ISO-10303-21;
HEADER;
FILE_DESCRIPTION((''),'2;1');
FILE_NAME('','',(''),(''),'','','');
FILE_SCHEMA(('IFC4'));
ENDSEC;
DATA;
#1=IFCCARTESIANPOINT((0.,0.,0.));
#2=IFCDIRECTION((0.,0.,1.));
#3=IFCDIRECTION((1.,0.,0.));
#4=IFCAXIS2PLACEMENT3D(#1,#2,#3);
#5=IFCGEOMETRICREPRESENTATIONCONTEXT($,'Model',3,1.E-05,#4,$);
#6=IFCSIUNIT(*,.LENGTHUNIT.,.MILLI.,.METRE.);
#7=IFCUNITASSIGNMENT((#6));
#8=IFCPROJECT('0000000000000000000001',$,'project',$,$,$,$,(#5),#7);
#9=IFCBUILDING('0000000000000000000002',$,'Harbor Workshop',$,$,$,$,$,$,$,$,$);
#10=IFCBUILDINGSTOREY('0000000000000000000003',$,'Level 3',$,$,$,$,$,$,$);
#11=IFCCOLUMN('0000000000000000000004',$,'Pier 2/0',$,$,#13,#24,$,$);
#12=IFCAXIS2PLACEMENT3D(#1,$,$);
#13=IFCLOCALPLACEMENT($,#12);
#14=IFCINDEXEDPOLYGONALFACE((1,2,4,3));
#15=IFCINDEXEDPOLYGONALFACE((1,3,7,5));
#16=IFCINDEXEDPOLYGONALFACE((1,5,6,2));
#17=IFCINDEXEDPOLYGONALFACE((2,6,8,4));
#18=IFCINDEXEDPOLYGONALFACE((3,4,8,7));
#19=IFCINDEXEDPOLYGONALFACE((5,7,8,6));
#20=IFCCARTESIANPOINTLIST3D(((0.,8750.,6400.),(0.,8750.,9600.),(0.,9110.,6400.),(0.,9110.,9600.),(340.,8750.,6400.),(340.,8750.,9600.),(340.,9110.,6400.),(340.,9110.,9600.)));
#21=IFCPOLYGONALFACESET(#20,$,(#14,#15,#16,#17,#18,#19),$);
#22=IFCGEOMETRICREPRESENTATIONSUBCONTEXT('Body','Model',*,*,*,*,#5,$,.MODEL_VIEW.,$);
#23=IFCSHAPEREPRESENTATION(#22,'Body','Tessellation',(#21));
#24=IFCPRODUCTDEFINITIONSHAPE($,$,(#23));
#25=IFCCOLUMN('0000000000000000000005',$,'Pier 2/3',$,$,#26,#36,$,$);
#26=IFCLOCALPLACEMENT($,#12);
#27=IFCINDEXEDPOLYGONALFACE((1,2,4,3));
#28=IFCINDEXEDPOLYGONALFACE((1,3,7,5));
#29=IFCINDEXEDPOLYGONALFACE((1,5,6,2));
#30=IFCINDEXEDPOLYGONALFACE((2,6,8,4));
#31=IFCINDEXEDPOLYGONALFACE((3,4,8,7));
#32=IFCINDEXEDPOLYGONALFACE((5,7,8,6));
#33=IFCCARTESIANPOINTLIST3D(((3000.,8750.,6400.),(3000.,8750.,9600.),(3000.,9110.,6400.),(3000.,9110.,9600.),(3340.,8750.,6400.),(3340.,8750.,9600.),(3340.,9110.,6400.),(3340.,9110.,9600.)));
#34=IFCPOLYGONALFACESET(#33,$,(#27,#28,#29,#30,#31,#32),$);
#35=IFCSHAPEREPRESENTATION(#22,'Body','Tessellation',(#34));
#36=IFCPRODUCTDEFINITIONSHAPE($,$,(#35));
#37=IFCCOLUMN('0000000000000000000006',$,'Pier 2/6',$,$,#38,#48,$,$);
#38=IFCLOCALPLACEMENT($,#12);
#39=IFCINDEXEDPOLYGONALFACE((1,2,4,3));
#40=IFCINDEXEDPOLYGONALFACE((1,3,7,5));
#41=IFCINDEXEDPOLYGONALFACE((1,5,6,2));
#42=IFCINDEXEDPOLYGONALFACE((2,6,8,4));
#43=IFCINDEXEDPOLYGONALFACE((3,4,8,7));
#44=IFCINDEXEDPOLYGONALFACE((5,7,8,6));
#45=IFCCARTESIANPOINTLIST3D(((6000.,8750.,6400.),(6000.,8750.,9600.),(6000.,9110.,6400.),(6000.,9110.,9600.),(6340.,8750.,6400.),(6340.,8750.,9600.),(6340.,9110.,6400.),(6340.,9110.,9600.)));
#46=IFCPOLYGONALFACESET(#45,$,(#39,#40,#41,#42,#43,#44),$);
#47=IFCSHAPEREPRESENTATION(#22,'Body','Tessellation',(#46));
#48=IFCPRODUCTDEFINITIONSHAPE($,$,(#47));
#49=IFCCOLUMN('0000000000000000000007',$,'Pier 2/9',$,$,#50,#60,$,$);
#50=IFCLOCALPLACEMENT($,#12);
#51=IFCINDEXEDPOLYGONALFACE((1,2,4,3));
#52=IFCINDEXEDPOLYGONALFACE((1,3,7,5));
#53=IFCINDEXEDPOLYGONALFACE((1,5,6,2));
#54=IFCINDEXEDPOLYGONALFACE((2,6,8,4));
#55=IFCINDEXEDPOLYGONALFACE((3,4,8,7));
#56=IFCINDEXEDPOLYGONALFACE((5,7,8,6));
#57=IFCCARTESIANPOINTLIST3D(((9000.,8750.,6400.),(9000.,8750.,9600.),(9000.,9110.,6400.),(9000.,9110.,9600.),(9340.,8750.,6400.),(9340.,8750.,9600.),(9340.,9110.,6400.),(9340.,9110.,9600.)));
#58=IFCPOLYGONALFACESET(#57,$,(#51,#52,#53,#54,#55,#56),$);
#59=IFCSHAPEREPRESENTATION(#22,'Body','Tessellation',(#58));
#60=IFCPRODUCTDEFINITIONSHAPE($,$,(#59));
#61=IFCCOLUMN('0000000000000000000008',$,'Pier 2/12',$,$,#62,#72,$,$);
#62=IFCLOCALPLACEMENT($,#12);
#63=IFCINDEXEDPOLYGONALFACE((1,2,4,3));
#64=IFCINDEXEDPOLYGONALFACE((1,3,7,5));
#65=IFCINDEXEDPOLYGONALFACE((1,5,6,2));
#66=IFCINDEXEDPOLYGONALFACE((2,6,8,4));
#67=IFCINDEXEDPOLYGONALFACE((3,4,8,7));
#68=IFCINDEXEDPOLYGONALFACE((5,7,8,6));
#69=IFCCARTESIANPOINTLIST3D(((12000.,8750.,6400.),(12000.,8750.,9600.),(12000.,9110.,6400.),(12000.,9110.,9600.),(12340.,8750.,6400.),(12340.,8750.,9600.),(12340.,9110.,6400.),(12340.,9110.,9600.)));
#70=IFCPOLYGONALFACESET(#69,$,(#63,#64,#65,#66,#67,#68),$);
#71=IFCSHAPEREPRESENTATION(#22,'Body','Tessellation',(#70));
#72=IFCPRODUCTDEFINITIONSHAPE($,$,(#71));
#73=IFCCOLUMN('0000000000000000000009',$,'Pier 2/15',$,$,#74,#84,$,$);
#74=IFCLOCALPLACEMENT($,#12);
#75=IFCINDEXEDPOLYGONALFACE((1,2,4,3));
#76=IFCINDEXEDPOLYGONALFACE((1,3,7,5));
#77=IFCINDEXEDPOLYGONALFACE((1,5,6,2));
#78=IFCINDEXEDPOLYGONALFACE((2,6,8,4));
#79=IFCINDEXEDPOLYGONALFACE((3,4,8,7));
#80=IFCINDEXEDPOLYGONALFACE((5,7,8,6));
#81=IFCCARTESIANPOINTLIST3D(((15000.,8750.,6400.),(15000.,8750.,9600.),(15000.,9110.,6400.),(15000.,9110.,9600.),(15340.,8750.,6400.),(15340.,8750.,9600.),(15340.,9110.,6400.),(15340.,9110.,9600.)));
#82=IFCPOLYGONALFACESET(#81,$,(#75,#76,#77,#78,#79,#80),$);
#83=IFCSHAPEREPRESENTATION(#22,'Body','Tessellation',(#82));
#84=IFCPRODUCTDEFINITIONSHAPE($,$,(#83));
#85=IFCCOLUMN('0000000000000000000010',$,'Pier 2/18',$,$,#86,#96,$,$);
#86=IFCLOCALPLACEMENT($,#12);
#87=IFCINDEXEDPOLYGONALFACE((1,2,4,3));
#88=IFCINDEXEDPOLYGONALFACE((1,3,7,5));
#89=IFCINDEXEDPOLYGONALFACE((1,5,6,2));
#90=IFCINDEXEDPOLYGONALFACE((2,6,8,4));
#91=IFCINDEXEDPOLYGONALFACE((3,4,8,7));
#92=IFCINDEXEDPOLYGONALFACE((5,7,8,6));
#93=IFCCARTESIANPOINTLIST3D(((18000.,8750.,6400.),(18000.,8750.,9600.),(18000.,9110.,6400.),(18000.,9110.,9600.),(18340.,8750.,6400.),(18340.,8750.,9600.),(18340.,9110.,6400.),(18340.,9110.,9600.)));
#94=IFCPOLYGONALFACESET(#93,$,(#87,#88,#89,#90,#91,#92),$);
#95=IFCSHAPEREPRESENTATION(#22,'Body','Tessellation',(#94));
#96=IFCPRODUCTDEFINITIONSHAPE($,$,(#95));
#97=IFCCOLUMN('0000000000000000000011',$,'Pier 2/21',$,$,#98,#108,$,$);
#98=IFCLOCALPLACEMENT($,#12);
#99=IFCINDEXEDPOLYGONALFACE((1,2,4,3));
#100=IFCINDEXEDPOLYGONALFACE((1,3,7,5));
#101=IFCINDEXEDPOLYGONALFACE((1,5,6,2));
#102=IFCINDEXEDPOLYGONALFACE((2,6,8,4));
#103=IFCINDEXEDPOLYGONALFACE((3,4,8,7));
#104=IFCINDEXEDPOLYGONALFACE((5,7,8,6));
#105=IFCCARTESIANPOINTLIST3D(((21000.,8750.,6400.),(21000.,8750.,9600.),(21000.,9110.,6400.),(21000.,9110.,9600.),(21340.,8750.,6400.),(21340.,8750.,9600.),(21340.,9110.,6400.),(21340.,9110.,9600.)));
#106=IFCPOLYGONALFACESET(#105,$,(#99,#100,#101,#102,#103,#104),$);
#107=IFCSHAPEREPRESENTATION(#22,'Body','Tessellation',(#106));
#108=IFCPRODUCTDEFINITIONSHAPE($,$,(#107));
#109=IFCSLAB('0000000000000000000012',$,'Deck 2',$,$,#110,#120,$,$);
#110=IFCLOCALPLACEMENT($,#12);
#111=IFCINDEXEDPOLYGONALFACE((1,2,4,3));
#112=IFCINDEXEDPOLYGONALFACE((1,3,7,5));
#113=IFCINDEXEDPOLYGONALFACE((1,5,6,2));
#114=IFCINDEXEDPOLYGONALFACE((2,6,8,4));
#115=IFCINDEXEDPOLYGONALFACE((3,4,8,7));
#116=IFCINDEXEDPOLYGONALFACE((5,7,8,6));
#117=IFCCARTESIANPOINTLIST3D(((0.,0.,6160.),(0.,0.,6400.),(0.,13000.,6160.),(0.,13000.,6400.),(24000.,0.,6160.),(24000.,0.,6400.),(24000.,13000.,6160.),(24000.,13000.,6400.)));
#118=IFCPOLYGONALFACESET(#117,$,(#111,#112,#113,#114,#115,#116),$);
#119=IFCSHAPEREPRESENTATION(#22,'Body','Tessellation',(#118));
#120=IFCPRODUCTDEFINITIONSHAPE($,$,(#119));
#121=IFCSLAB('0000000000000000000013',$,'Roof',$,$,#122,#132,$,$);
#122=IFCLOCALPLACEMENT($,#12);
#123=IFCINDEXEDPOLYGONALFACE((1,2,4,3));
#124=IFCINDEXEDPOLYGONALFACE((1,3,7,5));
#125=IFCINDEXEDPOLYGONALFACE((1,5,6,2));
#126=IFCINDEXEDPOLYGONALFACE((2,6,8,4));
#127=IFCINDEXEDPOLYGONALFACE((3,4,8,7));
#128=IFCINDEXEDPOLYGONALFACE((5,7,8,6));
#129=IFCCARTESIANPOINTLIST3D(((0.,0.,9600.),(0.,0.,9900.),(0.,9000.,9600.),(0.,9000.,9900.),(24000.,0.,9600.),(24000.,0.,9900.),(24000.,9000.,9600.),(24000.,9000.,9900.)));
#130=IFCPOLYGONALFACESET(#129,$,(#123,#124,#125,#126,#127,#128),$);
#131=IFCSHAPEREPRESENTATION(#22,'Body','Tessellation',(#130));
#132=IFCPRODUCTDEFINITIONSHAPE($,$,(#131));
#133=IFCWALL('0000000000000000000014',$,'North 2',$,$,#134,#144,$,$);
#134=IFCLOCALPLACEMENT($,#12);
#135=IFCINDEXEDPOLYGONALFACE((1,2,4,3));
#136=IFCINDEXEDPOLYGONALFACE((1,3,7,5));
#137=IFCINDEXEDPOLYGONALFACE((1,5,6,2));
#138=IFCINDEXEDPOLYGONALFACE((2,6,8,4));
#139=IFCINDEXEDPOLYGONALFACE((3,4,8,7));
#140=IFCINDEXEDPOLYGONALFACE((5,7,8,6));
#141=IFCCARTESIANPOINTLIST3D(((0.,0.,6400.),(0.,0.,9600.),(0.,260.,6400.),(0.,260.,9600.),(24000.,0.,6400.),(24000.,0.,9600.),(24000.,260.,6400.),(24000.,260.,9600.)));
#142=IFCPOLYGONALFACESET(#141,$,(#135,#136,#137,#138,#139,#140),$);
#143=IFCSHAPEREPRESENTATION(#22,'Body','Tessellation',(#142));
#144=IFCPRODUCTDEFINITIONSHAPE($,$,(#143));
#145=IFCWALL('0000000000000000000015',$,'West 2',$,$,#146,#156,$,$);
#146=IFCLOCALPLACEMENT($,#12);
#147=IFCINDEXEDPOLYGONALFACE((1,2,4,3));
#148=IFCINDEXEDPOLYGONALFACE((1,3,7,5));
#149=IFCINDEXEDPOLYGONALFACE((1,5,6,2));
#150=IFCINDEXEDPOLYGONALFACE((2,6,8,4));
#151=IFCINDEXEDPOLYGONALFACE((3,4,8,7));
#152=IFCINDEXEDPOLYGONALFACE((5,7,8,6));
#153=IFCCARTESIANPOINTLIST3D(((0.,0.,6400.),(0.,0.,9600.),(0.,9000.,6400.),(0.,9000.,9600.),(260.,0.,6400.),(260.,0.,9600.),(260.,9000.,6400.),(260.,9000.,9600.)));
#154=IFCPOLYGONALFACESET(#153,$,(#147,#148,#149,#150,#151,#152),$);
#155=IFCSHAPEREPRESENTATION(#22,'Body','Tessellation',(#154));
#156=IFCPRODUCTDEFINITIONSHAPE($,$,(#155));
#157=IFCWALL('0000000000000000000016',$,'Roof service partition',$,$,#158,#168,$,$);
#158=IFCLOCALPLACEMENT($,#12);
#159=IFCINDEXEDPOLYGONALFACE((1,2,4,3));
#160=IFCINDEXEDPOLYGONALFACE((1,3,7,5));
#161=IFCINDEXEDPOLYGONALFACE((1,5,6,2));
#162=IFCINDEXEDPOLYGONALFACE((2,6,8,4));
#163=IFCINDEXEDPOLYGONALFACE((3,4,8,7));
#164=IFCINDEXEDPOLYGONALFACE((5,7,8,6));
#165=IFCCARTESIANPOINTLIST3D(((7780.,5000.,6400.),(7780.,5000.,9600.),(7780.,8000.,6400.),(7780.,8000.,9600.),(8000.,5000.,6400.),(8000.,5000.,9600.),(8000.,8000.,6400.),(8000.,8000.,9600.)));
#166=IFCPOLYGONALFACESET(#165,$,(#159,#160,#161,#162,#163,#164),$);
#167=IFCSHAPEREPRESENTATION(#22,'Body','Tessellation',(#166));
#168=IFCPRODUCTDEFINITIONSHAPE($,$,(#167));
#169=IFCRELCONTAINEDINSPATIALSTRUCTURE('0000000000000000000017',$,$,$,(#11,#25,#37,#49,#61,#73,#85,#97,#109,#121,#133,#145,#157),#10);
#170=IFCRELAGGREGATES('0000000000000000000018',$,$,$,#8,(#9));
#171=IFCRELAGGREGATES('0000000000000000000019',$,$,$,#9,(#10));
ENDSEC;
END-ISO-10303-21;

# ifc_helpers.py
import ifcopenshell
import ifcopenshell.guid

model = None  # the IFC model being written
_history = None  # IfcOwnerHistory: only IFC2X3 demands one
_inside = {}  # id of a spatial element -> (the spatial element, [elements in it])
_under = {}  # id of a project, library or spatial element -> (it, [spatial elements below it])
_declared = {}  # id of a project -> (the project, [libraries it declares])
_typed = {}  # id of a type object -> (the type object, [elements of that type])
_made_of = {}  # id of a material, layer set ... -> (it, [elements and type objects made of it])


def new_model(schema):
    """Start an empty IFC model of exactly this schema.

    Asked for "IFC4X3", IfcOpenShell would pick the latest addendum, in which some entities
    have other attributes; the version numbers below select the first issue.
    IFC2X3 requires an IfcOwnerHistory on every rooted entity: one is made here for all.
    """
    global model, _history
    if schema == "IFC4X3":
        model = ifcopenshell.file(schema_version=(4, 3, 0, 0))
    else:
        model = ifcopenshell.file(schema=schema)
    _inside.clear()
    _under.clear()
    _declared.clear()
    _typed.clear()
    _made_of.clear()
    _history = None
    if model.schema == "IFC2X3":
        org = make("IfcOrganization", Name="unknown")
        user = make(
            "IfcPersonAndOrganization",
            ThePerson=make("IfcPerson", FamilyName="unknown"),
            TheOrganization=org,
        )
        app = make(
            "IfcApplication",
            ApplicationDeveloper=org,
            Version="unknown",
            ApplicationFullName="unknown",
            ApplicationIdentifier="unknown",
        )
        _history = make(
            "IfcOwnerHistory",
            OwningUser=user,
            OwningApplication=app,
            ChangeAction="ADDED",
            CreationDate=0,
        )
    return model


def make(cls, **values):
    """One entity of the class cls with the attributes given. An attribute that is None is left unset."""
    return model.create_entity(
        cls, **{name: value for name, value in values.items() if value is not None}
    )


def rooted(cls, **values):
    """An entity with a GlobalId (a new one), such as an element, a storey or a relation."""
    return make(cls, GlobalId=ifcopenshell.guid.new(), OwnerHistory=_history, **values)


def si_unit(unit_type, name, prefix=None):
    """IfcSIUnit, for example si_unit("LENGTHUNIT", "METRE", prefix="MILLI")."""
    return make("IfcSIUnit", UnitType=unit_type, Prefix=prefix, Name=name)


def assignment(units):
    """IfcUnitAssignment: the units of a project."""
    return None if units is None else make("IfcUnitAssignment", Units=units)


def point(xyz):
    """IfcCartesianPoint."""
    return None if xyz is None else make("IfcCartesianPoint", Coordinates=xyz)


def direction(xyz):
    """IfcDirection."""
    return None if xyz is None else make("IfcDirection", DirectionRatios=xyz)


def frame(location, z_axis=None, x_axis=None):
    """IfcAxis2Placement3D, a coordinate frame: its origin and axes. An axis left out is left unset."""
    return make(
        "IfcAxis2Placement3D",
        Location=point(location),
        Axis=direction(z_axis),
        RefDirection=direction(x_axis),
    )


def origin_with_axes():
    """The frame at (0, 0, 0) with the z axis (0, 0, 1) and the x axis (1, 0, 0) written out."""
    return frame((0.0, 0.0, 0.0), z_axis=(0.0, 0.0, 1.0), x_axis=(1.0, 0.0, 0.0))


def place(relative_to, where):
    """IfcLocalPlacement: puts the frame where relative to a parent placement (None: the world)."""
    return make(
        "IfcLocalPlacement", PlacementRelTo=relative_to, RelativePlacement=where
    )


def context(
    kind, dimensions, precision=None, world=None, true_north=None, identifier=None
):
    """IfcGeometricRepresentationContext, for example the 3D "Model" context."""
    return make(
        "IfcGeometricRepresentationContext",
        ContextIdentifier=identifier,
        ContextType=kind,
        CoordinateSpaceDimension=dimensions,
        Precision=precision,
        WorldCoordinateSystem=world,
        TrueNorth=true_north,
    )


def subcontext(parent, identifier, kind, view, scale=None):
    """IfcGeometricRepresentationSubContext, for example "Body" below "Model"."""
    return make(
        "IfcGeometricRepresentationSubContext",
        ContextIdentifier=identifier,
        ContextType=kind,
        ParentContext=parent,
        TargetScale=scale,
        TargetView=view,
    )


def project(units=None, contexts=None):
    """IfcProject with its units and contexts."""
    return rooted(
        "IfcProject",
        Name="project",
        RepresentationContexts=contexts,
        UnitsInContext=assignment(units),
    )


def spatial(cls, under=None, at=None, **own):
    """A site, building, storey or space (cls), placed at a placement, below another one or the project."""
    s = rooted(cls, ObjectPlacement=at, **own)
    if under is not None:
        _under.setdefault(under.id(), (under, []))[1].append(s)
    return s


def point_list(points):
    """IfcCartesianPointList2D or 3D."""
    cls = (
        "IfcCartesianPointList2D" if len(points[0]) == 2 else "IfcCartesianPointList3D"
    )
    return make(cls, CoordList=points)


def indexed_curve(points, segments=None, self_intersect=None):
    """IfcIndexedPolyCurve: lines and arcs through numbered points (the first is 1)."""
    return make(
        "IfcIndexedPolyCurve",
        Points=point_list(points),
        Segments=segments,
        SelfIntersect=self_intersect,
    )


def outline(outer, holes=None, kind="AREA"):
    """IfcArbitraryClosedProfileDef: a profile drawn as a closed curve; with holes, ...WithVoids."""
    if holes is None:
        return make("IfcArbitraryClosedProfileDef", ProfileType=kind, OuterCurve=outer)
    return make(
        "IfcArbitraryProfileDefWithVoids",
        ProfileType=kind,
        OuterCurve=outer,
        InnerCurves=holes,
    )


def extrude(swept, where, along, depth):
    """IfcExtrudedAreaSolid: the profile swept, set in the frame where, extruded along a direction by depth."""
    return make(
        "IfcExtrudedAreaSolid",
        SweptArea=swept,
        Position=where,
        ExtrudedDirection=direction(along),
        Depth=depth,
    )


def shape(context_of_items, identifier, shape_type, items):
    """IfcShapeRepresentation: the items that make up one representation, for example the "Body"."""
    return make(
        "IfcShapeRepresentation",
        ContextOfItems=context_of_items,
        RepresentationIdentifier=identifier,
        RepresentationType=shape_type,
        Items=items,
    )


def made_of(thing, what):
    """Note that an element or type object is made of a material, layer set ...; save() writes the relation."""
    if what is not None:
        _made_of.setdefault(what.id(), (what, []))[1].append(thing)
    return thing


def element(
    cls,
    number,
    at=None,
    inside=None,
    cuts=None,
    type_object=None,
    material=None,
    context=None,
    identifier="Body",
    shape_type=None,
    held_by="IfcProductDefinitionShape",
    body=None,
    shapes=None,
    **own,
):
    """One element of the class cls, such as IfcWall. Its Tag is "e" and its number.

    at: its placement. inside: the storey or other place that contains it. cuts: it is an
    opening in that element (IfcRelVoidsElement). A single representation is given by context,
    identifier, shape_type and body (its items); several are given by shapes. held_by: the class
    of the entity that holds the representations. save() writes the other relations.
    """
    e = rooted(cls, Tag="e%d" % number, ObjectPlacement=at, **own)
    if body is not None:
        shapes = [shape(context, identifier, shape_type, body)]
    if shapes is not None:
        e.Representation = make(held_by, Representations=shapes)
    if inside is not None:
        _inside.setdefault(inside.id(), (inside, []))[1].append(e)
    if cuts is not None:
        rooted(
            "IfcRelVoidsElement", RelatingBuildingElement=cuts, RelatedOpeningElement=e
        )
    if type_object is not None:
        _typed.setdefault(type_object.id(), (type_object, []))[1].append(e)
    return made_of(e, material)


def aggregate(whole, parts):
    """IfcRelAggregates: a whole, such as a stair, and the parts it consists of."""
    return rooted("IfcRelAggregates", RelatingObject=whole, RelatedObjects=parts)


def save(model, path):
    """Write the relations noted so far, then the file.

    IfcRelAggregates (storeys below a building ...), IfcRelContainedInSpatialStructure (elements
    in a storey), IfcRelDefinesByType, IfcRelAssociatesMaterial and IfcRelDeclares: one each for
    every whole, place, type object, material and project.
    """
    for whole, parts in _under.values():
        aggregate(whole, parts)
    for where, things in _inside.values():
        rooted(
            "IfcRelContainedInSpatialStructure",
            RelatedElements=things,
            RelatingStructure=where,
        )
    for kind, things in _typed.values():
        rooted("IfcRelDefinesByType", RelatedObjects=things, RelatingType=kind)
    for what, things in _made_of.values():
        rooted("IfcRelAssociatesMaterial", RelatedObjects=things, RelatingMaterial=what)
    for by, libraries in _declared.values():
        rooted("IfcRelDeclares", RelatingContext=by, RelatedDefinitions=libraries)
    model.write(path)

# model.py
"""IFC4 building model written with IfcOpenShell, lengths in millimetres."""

from ifc_helpers import new_model, si_unit, frame, origin_with_axes, place, context, subcontext, project, spatial, indexed_curve, outline, extrude, element, save


model = new_model("IFC4")

# Units and contexts
model_context = context("Model", 3, precision=1e-05, world=origin_with_axes())
body_context = subcontext(model_context, "Body", "Model", "MODEL_VIEW")
ifc_project = project(units=[si_unit("LENGTHUNIT", "METRE", prefix="MILLI")], contexts=[model_context])

# Building, storey
building = spatial("IfcBuilding", under=ifc_project, Name="Harbor Workshop")
storey = spatial("IfcBuildingStorey", under=building, Name="Level 3")

# Columns
for number, where, z_axis, x_axis, name in (
    (1, (0.0, 8750.0, 6400.0), (0.0, 0.0, 1.0), (1.0, 0.0, 0.0), "Pier 2/0"),
    (2, (3000.0, 8750.0, 6400.0), (0.0, 0.0, 1.0), (1.0, 0.0, 0.0), "Pier 2/3"),
    (3, (6000.0, 8750.0, 6400.0), (0.0, 0.0, 1.0), (1.0, 0.0, 0.0), "Pier 2/6"),
    (4, (9000.0, 8750.0, 6400.0), (0.0, 0.0, 1.0), (1.0, 0.0, 0.0), "Pier 2/9"),
    (5, (12000.0, 8750.0, 6400.0), (0.0, 0.0, 1.0), (1.0, 0.0, 0.0), "Pier 2/12"),
    (6, (15000.0, 8750.0, 6400.0), (0.0, 0.0, 1.0), (1.0, 0.0, 0.0), "Pier 2/15"),
    (7, (18000.0, 8750.0, 6400.0), (0.0, 0.0, 1.0), (1.0, 0.0, 0.0), "Pier 2/18"),
    (8, (21000.0, 8750.0, 6400.0), (0.0, 0.0, 1.0), (1.0, 0.0, 0.0), "Pier 2/21"),
):
    element("IfcColumn", number, at=place(None, frame(where, z_axis=z_axis, x_axis=x_axis)), inside=storey, Name=name, context=body_context, shape_type="SweptSolid", body=[
        extrude(outline(indexed_curve([(0.0, 0.0), (0.0, 360.0), (340.0, 360.0), (340.0, 0.0), (0.0, 0.0)], self_intersect=False)), origin_with_axes(), (0.0, 0.0, 1.0), 3200.0),
    ])

# Slabs
slab_1_placement = place(None, frame((0.0, 0.0, 6160.0), z_axis=(0.0, 0.0, 1.0), x_axis=(1.0, 0.0, 0.0)))
element("IfcSlab", 9, at=slab_1_placement, inside=storey, Name="Deck 2", context=body_context, shape_type="SweptSolid", body=[
    extrude(outline(indexed_curve([(0.0, 0.0), (0.0, 13000.0), (24000.0, 13000.0), (24000.0, 0.0), (0.0, 0.0)], self_intersect=False)), origin_with_axes(), (0.0, 0.0, 1.0), 240.0),
])
slab_2_placement = place(None, frame((0.0, 0.0, 9600.0), z_axis=(0.0, 0.0, 1.0), x_axis=(1.0, 0.0, 0.0)))
element("IfcSlab", 10, at=slab_2_placement, inside=storey, Name="Roof", context=body_context, shape_type="SweptSolid", body=[
    extrude(outline(indexed_curve([(0.0, 0.0), (0.0, 9000.0), (24000.0, 9000.0), (24000.0, 0.0), (0.0, 0.0)], self_intersect=False)), origin_with_axes(), (0.0, 0.0, 1.0), 300.0),
])

# Walls
wall_1_placement = place(None, frame((0.0, 0.0, 6400.0), z_axis=(0.0, 0.0, 1.0), x_axis=(1.0, 0.0, 0.0)))
element("IfcWall", 11, at=wall_1_placement, inside=storey, Name="North 2", context=body_context, shape_type="SweptSolid", body=[
    extrude(outline(indexed_curve([(0.0, 0.0), (0.0, 260.0), (24000.0, 260.0), (24000.0, 0.0), (0.0, 0.0)], self_intersect=False)), origin_with_axes(), (0.0, 0.0, 1.0), 3200.0),
])
wall_2_placement = place(None, frame((260.0, 0.0, 6400.0), z_axis=(0.0, 0.0, 1.0), x_axis=(0.0, 1.0, 0.0)))
element("IfcWall", 12, at=wall_2_placement, inside=storey, Name="West 2", context=body_context, shape_type="SweptSolid", body=[
    extrude(outline(indexed_curve([(0.0, 0.0), (0.0, 260.0), (9000.0, 260.0), (9000.0, 0.0), (0.0, 0.0)], self_intersect=False)), origin_with_axes(), (0.0, 0.0, 1.0), 3200.0),
])
wall_3_placement = place(None, frame((8000.0, 5000.0, 6400.0), z_axis=(0.0, 0.0, 1.0), x_axis=(0.0, 1.0, 0.0)))
element("IfcWall", 13, at=wall_3_placement, inside=storey, Name="Roof service partition", context=body_context, shape_type="SweptSolid", body=[
    extrude(outline(indexed_curve([(0.0, 0.0), (0.0, 220.0), (3000.0, 220.0), (3000.0, 0.0), (0.0, 0.0)], self_intersect=False)), origin_with_axes(), (0.0, 0.0, 1.0), 3200.0),
])

save(model, "model.ifc")
